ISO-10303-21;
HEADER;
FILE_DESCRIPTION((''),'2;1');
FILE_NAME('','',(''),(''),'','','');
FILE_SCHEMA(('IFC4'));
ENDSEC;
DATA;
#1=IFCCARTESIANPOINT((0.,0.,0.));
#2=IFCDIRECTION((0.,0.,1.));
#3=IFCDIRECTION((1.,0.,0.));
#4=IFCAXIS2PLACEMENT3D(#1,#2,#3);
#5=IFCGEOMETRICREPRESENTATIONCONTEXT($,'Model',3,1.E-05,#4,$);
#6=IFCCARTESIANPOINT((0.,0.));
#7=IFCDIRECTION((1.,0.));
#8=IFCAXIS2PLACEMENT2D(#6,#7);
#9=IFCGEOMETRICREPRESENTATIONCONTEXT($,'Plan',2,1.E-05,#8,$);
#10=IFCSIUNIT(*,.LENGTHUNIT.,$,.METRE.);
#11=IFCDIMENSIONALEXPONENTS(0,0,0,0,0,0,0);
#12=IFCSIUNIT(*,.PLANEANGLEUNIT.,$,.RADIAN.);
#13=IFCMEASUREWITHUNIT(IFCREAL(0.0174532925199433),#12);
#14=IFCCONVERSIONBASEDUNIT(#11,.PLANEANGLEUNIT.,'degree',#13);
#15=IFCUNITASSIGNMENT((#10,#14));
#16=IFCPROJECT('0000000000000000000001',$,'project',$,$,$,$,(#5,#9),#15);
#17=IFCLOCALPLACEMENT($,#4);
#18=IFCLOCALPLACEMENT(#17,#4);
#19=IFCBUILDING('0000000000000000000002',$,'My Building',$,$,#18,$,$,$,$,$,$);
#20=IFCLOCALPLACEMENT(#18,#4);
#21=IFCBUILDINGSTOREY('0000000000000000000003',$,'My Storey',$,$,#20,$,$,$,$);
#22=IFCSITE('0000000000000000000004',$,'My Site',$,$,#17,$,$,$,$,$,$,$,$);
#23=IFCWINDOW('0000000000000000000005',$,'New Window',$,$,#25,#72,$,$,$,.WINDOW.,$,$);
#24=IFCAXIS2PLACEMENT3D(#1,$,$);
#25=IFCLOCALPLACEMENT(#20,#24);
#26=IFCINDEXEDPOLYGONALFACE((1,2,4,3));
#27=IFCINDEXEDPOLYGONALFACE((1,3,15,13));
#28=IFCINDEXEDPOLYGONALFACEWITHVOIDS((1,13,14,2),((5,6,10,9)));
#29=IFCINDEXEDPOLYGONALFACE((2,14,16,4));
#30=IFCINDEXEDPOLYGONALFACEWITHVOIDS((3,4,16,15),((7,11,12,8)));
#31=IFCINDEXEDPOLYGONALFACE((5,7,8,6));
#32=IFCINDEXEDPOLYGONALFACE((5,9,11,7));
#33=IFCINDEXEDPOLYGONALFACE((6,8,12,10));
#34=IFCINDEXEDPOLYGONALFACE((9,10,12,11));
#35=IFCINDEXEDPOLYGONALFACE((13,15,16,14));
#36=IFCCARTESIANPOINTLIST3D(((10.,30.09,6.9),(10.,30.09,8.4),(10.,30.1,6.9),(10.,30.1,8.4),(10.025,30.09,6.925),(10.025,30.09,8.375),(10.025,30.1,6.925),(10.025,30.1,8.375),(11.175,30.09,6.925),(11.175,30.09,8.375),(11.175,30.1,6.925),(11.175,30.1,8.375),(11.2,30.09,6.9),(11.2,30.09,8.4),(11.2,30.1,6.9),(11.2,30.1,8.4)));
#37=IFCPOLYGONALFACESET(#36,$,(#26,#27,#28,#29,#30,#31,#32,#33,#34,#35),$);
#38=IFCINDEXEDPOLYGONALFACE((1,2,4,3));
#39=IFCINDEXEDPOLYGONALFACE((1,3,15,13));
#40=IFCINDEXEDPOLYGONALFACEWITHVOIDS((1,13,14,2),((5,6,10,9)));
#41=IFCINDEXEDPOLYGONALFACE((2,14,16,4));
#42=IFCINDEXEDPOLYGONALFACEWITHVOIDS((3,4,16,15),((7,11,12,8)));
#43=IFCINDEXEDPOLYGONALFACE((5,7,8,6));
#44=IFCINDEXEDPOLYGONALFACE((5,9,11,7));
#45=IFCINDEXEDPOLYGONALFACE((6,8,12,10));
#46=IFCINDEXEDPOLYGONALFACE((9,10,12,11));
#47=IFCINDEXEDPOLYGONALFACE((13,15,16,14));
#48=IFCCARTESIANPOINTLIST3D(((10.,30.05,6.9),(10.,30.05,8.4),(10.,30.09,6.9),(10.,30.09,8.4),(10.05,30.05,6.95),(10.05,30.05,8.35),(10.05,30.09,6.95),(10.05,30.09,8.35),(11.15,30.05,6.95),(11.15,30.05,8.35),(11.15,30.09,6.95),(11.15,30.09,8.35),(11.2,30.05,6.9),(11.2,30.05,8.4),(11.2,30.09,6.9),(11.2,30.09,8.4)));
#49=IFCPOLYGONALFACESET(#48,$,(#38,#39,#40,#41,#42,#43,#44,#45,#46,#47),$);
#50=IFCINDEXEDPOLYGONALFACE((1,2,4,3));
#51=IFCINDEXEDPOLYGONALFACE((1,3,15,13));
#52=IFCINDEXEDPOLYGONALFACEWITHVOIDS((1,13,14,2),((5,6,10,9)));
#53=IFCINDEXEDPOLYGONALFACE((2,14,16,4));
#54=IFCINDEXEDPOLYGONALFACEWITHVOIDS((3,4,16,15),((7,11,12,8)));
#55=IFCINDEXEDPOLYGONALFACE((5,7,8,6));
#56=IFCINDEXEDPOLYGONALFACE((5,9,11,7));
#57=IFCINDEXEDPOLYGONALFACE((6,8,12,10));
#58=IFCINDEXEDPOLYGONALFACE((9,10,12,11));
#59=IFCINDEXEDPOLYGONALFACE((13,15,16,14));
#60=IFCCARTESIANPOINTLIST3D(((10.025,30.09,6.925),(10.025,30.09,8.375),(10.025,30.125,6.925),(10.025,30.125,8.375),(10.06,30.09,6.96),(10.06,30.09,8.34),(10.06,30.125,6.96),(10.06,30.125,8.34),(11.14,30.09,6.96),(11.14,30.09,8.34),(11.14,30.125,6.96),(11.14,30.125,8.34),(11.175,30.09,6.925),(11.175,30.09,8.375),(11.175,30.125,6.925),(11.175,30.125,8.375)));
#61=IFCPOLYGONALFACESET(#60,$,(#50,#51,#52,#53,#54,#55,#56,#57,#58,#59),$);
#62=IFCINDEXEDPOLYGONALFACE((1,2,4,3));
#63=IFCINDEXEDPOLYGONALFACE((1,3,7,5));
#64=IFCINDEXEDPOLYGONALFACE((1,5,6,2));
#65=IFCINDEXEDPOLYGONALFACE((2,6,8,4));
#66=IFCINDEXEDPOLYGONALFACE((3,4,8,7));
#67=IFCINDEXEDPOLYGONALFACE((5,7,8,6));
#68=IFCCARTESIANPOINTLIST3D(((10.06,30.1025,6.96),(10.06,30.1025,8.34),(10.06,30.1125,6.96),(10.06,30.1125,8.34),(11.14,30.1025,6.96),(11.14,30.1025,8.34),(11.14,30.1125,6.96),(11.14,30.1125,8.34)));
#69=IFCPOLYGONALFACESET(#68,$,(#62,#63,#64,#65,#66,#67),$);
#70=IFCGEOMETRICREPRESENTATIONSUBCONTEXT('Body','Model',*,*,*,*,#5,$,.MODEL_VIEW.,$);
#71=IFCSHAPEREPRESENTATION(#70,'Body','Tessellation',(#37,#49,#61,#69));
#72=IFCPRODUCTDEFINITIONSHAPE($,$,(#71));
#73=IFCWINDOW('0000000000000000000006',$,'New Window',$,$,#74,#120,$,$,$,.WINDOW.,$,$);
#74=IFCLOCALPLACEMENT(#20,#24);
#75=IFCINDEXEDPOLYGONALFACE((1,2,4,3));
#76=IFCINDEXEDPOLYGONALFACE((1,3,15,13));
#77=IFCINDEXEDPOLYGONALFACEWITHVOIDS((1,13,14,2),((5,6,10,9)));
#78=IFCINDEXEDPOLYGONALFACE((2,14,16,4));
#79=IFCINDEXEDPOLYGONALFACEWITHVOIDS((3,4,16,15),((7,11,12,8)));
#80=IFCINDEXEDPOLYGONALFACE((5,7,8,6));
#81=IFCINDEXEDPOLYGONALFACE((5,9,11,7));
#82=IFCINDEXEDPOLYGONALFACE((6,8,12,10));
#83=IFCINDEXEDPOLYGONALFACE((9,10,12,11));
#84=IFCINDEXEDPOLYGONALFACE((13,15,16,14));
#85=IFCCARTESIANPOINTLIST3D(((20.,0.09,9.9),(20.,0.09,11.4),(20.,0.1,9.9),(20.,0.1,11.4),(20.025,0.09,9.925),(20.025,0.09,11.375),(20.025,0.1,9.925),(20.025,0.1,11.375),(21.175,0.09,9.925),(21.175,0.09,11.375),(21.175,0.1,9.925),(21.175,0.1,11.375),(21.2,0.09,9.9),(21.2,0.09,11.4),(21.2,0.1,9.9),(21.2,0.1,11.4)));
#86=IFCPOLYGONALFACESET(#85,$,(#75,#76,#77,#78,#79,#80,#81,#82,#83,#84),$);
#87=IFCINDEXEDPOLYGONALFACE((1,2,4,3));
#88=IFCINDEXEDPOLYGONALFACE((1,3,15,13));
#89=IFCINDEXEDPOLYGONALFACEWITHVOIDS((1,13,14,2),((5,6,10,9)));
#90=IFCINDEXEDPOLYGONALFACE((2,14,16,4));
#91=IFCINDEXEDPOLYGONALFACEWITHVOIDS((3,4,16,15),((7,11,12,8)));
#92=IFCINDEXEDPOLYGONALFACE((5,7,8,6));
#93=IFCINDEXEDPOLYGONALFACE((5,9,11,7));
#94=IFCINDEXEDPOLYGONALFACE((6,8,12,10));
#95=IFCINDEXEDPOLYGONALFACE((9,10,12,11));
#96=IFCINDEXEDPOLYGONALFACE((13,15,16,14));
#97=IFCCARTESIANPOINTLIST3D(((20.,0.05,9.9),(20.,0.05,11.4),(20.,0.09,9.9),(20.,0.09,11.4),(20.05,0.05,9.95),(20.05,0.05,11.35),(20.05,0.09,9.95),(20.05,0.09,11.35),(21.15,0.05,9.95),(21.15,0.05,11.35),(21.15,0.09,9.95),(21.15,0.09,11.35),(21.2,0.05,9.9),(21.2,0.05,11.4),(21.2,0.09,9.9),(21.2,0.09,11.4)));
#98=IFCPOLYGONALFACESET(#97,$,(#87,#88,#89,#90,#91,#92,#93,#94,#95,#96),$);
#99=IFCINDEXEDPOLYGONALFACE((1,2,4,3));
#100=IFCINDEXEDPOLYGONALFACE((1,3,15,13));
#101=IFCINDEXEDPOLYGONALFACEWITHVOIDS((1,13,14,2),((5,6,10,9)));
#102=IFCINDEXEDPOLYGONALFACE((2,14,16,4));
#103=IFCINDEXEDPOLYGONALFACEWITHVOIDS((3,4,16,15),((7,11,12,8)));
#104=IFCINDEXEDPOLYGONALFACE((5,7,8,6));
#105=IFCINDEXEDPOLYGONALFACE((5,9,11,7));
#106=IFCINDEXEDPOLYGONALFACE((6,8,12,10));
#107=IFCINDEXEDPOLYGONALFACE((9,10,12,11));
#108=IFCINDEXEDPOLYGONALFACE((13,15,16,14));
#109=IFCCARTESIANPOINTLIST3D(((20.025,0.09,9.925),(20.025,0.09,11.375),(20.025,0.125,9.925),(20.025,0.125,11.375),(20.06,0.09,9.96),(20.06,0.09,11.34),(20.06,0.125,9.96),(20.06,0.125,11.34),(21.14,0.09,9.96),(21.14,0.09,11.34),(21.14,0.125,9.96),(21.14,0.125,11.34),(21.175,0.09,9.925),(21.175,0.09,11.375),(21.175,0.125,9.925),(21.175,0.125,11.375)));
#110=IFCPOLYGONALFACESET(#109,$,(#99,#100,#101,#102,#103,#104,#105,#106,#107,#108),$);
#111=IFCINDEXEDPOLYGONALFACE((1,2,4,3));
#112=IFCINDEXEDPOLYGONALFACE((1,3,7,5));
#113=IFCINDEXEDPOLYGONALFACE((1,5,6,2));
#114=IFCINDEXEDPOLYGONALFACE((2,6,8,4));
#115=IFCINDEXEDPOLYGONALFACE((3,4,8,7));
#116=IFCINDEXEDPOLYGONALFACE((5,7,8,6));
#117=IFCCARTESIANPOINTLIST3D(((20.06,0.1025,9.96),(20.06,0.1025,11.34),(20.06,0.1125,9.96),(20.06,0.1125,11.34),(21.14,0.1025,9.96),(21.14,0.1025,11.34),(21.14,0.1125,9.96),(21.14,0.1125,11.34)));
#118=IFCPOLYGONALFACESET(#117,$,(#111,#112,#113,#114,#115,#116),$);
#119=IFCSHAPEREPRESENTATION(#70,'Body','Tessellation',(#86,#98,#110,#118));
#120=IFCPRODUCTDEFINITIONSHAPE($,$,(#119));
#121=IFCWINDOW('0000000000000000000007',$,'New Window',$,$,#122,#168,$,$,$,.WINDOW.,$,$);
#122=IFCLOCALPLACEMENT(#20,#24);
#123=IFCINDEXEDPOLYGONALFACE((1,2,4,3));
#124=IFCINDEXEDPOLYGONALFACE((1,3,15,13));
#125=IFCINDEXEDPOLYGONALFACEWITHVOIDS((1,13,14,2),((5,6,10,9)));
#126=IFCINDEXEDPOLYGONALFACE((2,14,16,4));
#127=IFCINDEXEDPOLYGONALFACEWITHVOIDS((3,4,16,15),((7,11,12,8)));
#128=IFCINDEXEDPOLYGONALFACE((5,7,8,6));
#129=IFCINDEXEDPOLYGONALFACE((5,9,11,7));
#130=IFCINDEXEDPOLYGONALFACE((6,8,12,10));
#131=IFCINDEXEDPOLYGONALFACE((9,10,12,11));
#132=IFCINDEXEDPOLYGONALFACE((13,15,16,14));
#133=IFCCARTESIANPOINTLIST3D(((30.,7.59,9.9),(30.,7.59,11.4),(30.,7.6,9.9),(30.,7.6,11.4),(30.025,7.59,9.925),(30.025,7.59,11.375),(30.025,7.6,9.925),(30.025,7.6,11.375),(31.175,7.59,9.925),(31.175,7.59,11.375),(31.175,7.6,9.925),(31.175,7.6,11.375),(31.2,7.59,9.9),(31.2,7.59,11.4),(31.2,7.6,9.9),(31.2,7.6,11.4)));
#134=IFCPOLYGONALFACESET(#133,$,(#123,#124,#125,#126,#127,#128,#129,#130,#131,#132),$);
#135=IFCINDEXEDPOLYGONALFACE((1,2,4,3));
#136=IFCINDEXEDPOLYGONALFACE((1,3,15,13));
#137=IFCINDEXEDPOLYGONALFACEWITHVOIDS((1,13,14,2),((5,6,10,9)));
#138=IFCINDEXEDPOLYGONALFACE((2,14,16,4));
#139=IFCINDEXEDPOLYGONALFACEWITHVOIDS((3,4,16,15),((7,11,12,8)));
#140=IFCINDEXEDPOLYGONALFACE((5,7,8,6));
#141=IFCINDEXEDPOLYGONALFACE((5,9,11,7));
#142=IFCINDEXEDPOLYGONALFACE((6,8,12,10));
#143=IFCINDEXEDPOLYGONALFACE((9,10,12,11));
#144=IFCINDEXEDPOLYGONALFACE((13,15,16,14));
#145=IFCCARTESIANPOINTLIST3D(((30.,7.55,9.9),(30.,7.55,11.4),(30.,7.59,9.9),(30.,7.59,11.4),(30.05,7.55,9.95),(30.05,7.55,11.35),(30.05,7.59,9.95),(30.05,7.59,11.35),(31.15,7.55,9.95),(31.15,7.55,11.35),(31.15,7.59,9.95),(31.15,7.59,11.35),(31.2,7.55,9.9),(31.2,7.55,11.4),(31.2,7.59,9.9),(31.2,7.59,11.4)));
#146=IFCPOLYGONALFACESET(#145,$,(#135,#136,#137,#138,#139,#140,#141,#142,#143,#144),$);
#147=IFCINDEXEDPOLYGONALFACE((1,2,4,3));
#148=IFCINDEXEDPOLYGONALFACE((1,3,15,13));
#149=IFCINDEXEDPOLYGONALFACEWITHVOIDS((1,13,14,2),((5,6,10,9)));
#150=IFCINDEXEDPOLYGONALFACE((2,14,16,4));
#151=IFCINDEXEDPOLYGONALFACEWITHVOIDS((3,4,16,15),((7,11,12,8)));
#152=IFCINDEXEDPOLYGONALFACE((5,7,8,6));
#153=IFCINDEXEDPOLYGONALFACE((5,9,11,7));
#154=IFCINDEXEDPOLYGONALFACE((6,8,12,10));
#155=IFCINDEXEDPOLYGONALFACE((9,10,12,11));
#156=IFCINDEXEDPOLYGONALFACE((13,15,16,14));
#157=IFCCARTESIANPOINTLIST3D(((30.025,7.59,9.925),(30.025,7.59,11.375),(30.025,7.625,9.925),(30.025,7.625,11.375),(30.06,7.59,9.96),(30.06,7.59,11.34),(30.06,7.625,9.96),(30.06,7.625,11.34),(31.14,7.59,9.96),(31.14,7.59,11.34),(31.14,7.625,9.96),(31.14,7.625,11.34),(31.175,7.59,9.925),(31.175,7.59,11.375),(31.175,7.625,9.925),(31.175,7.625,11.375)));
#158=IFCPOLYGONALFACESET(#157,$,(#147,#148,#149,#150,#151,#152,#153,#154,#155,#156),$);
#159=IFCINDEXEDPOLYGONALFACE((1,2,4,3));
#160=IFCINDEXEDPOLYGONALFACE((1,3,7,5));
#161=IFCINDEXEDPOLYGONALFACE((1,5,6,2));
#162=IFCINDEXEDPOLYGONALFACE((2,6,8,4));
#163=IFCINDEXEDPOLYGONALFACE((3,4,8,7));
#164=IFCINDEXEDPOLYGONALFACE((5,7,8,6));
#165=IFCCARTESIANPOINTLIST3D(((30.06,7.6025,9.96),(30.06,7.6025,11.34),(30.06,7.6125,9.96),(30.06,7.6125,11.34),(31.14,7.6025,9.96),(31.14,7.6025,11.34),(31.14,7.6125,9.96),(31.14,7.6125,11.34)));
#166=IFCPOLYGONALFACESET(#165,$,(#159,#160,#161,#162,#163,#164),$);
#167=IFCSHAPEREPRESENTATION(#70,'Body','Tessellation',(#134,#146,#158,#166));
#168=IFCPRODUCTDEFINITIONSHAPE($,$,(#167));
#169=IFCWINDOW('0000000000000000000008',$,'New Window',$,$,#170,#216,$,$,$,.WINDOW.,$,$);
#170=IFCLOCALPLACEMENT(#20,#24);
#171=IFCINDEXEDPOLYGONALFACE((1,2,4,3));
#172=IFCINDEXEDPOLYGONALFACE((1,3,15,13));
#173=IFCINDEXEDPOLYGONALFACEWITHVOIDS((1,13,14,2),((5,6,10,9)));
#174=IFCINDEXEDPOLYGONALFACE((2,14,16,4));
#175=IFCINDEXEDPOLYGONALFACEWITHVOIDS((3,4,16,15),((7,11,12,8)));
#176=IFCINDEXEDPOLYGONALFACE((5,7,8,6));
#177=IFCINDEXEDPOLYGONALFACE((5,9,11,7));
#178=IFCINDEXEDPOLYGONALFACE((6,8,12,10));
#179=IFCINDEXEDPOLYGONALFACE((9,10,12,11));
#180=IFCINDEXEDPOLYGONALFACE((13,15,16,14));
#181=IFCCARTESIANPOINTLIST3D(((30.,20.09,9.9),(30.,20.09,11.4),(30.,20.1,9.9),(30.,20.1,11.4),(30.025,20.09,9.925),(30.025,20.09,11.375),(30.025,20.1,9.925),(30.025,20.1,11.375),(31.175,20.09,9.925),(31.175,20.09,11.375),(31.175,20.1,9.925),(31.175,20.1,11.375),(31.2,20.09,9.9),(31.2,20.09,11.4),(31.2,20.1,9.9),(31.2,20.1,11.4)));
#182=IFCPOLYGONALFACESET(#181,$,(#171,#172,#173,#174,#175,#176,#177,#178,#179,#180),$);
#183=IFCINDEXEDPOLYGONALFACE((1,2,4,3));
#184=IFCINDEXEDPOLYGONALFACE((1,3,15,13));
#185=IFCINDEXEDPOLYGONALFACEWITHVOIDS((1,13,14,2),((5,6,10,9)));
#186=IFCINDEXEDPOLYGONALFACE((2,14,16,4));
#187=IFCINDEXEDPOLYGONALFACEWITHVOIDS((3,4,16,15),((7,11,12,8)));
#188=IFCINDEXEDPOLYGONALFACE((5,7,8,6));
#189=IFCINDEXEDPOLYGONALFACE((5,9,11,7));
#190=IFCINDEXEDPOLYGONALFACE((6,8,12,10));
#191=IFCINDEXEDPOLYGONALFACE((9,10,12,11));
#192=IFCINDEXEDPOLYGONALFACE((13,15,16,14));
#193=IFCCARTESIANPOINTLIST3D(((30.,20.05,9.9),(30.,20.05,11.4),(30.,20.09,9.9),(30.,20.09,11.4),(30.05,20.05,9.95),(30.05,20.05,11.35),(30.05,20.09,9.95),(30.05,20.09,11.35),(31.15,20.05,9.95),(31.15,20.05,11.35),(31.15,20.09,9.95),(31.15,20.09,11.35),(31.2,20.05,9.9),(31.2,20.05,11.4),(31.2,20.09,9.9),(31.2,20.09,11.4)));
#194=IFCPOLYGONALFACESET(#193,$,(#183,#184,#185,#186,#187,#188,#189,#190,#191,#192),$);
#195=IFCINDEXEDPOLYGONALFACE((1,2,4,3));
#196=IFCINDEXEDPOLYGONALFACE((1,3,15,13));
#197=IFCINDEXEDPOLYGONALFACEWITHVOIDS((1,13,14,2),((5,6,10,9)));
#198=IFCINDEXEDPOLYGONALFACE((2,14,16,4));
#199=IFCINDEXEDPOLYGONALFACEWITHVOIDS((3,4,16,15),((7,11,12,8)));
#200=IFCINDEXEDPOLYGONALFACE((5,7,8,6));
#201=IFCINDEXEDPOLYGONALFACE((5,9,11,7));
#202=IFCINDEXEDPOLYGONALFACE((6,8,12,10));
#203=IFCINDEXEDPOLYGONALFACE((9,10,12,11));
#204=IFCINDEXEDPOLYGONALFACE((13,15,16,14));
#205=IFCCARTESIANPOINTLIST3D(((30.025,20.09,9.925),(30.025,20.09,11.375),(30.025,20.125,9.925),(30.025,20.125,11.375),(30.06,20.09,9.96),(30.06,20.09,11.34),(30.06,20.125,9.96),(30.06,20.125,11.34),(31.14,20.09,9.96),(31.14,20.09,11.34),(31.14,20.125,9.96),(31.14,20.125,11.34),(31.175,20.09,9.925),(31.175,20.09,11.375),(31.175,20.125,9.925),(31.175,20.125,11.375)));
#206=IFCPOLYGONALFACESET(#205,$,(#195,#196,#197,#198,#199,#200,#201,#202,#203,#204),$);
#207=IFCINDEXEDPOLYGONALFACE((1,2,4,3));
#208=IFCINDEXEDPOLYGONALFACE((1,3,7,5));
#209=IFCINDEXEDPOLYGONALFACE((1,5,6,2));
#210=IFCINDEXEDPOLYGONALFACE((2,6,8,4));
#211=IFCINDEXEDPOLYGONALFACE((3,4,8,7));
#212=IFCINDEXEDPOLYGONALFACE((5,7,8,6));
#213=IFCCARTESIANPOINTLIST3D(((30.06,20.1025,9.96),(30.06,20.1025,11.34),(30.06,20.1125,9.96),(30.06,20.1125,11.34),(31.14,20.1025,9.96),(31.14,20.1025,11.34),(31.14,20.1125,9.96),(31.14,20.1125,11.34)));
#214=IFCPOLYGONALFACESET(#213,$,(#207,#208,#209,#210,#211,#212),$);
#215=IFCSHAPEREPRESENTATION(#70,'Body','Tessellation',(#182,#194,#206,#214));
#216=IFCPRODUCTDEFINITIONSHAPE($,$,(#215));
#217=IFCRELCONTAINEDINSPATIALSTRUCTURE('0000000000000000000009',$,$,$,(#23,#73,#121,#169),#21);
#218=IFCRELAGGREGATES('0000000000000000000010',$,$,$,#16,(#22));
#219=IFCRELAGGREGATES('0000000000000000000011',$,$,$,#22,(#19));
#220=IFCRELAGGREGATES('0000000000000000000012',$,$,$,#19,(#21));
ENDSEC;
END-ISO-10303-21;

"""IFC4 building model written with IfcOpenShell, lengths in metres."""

from ifc_helpers import new_model, entity, si_unit, converted_unit, frame, origin_with_axes, origin_2d_with_axis, place, context, subcontext, project, spatial, line, indexed_curve, outline, extrude, element, save


model = new_model("IFC4")

# Units and contexts
model_context = context("Model", 3, precision=1e-05, world=origin_with_axes())
plan_context = context("Plan", 2, precision=1e-05, world=origin_2d_with_axis())
body_context = subcontext(model_context, "Body", "Model", "MODEL_VIEW")
ifc_project = project(units=[si_unit("LENGTHUNIT", "METRE"), converted_unit("PLANEANGLEUNIT", "degree", entity("IfcReal", 0.0174532925199433), si_unit("PLANEANGLEUNIT", "RADIAN"), dimensions=[0, 0, 0, 0, 0, 0, 0])], contexts=[model_context, plan_context])

# Site, building, storey
site_placement = place(None, origin_with_axes())
site = spatial("IfcSite", under=ifc_project, at=site_placement, Name="My Site")
building_placement = place(site_placement, origin_with_axes())
building = spatial("IfcBuilding", under=site, at=building_placement, Name="My Building")
storey_placement = place(building_placement, origin_with_axes())
storey = spatial("IfcBuildingStorey", under=building, at=storey_placement, Name="My Storey")

# Windows
for number, where, z_axis, x_axis, name in (
    (1, (10.0, 30.0, 6.9), (0.0, 0.0, 1.0), (1.0, 0.0, 0.0), "New Window"),
    (2, (20.0, 0.0, 9.9), (0.0, 0.0, 1.0), (1.0, 0.0, 0.0), "New Window"),
    (3, (30.0, 7.5, 9.9), (0.0, 0.0, 1.0), (1.0, 0.0, 0.0), "New Window"),
    (4, (30.0, 20.0, 9.9), (0.0, 0.0, 1.0), (1.0, 0.0, 0.0), "New Window"),
):
    element("IfcWindow", number, at=place(storey_placement, frame(where, z_axis=z_axis, x_axis=x_axis)), inside=storey, Name=name, PredefinedType="WINDOW", context=body_context, shape_type="SweptSolid", body=[
        extrude(outline(indexed_curve([(0.0, 0.0), (1.2, 0.0), (1.2, 1.5), (0.0, 1.5)], segments=[line(1, 2, 3, 4, 1)]), holes=[indexed_curve([(0.025, 0.025), (1.175, 0.025), (1.175, 1.475), (0.025, 1.475)], segments=[line(1, 2, 3, 4, 1)])]), frame((0.0, 0.09, 0.0), z_axis=(0.0, -1.0, 0.0), x_axis=(1.0, 0.0, 0.0)), (0.0, 0.0, -1.0), 0.01),
        extrude(outline(indexed_curve([(0.0, 0.0), (1.2, 0.0), (1.2, 1.5), (0.0, 1.5)], segments=[line(1, 2, 3, 4, 1)]), holes=[indexed_curve([(0.05, 0.05), (1.15, 0.05), (1.15, 1.45), (0.05, 1.45)], segments=[line(1, 2, 3, 4, 1)])]), frame((0.0, 0.05, 0.0), z_axis=(0.0, -1.0, 0.0), x_axis=(1.0, 0.0, 0.0)), (0.0, 0.0, -1.0), 0.04),
        extrude(outline(indexed_curve([(0.0, 0.0), (1.15, 0.0), (1.15, 1.45), (0.0, 1.45)], segments=[line(1, 2, 3, 4, 1)]), holes=[indexed_curve([(0.035, 0.035), (1.115, 0.035), (1.115, 1.415), (0.035, 1.415)], segments=[line(1, 2, 3, 4, 1)])]), frame((0.025, 0.09, 0.025), z_axis=(0.0, -1.0, 0.0), x_axis=(1.0, 0.0, 0.0)), (0.0, 0.0, -1.0), 0.035),
        extrude(outline(indexed_curve([(0.035, 0.035), (1.115, 0.035), (1.115, 1.415), (0.035, 1.415)], segments=[line(1, 2, 3, 4, 1)])), frame((0.025, 0.1025, 0.025), z_axis=(0.0, -1.0, 0.0), x_axis=(1.0, 0.0, 0.0)), (0.0, 0.0, -1.0), 0.01),
    ])

save(model, "model.ifc")
